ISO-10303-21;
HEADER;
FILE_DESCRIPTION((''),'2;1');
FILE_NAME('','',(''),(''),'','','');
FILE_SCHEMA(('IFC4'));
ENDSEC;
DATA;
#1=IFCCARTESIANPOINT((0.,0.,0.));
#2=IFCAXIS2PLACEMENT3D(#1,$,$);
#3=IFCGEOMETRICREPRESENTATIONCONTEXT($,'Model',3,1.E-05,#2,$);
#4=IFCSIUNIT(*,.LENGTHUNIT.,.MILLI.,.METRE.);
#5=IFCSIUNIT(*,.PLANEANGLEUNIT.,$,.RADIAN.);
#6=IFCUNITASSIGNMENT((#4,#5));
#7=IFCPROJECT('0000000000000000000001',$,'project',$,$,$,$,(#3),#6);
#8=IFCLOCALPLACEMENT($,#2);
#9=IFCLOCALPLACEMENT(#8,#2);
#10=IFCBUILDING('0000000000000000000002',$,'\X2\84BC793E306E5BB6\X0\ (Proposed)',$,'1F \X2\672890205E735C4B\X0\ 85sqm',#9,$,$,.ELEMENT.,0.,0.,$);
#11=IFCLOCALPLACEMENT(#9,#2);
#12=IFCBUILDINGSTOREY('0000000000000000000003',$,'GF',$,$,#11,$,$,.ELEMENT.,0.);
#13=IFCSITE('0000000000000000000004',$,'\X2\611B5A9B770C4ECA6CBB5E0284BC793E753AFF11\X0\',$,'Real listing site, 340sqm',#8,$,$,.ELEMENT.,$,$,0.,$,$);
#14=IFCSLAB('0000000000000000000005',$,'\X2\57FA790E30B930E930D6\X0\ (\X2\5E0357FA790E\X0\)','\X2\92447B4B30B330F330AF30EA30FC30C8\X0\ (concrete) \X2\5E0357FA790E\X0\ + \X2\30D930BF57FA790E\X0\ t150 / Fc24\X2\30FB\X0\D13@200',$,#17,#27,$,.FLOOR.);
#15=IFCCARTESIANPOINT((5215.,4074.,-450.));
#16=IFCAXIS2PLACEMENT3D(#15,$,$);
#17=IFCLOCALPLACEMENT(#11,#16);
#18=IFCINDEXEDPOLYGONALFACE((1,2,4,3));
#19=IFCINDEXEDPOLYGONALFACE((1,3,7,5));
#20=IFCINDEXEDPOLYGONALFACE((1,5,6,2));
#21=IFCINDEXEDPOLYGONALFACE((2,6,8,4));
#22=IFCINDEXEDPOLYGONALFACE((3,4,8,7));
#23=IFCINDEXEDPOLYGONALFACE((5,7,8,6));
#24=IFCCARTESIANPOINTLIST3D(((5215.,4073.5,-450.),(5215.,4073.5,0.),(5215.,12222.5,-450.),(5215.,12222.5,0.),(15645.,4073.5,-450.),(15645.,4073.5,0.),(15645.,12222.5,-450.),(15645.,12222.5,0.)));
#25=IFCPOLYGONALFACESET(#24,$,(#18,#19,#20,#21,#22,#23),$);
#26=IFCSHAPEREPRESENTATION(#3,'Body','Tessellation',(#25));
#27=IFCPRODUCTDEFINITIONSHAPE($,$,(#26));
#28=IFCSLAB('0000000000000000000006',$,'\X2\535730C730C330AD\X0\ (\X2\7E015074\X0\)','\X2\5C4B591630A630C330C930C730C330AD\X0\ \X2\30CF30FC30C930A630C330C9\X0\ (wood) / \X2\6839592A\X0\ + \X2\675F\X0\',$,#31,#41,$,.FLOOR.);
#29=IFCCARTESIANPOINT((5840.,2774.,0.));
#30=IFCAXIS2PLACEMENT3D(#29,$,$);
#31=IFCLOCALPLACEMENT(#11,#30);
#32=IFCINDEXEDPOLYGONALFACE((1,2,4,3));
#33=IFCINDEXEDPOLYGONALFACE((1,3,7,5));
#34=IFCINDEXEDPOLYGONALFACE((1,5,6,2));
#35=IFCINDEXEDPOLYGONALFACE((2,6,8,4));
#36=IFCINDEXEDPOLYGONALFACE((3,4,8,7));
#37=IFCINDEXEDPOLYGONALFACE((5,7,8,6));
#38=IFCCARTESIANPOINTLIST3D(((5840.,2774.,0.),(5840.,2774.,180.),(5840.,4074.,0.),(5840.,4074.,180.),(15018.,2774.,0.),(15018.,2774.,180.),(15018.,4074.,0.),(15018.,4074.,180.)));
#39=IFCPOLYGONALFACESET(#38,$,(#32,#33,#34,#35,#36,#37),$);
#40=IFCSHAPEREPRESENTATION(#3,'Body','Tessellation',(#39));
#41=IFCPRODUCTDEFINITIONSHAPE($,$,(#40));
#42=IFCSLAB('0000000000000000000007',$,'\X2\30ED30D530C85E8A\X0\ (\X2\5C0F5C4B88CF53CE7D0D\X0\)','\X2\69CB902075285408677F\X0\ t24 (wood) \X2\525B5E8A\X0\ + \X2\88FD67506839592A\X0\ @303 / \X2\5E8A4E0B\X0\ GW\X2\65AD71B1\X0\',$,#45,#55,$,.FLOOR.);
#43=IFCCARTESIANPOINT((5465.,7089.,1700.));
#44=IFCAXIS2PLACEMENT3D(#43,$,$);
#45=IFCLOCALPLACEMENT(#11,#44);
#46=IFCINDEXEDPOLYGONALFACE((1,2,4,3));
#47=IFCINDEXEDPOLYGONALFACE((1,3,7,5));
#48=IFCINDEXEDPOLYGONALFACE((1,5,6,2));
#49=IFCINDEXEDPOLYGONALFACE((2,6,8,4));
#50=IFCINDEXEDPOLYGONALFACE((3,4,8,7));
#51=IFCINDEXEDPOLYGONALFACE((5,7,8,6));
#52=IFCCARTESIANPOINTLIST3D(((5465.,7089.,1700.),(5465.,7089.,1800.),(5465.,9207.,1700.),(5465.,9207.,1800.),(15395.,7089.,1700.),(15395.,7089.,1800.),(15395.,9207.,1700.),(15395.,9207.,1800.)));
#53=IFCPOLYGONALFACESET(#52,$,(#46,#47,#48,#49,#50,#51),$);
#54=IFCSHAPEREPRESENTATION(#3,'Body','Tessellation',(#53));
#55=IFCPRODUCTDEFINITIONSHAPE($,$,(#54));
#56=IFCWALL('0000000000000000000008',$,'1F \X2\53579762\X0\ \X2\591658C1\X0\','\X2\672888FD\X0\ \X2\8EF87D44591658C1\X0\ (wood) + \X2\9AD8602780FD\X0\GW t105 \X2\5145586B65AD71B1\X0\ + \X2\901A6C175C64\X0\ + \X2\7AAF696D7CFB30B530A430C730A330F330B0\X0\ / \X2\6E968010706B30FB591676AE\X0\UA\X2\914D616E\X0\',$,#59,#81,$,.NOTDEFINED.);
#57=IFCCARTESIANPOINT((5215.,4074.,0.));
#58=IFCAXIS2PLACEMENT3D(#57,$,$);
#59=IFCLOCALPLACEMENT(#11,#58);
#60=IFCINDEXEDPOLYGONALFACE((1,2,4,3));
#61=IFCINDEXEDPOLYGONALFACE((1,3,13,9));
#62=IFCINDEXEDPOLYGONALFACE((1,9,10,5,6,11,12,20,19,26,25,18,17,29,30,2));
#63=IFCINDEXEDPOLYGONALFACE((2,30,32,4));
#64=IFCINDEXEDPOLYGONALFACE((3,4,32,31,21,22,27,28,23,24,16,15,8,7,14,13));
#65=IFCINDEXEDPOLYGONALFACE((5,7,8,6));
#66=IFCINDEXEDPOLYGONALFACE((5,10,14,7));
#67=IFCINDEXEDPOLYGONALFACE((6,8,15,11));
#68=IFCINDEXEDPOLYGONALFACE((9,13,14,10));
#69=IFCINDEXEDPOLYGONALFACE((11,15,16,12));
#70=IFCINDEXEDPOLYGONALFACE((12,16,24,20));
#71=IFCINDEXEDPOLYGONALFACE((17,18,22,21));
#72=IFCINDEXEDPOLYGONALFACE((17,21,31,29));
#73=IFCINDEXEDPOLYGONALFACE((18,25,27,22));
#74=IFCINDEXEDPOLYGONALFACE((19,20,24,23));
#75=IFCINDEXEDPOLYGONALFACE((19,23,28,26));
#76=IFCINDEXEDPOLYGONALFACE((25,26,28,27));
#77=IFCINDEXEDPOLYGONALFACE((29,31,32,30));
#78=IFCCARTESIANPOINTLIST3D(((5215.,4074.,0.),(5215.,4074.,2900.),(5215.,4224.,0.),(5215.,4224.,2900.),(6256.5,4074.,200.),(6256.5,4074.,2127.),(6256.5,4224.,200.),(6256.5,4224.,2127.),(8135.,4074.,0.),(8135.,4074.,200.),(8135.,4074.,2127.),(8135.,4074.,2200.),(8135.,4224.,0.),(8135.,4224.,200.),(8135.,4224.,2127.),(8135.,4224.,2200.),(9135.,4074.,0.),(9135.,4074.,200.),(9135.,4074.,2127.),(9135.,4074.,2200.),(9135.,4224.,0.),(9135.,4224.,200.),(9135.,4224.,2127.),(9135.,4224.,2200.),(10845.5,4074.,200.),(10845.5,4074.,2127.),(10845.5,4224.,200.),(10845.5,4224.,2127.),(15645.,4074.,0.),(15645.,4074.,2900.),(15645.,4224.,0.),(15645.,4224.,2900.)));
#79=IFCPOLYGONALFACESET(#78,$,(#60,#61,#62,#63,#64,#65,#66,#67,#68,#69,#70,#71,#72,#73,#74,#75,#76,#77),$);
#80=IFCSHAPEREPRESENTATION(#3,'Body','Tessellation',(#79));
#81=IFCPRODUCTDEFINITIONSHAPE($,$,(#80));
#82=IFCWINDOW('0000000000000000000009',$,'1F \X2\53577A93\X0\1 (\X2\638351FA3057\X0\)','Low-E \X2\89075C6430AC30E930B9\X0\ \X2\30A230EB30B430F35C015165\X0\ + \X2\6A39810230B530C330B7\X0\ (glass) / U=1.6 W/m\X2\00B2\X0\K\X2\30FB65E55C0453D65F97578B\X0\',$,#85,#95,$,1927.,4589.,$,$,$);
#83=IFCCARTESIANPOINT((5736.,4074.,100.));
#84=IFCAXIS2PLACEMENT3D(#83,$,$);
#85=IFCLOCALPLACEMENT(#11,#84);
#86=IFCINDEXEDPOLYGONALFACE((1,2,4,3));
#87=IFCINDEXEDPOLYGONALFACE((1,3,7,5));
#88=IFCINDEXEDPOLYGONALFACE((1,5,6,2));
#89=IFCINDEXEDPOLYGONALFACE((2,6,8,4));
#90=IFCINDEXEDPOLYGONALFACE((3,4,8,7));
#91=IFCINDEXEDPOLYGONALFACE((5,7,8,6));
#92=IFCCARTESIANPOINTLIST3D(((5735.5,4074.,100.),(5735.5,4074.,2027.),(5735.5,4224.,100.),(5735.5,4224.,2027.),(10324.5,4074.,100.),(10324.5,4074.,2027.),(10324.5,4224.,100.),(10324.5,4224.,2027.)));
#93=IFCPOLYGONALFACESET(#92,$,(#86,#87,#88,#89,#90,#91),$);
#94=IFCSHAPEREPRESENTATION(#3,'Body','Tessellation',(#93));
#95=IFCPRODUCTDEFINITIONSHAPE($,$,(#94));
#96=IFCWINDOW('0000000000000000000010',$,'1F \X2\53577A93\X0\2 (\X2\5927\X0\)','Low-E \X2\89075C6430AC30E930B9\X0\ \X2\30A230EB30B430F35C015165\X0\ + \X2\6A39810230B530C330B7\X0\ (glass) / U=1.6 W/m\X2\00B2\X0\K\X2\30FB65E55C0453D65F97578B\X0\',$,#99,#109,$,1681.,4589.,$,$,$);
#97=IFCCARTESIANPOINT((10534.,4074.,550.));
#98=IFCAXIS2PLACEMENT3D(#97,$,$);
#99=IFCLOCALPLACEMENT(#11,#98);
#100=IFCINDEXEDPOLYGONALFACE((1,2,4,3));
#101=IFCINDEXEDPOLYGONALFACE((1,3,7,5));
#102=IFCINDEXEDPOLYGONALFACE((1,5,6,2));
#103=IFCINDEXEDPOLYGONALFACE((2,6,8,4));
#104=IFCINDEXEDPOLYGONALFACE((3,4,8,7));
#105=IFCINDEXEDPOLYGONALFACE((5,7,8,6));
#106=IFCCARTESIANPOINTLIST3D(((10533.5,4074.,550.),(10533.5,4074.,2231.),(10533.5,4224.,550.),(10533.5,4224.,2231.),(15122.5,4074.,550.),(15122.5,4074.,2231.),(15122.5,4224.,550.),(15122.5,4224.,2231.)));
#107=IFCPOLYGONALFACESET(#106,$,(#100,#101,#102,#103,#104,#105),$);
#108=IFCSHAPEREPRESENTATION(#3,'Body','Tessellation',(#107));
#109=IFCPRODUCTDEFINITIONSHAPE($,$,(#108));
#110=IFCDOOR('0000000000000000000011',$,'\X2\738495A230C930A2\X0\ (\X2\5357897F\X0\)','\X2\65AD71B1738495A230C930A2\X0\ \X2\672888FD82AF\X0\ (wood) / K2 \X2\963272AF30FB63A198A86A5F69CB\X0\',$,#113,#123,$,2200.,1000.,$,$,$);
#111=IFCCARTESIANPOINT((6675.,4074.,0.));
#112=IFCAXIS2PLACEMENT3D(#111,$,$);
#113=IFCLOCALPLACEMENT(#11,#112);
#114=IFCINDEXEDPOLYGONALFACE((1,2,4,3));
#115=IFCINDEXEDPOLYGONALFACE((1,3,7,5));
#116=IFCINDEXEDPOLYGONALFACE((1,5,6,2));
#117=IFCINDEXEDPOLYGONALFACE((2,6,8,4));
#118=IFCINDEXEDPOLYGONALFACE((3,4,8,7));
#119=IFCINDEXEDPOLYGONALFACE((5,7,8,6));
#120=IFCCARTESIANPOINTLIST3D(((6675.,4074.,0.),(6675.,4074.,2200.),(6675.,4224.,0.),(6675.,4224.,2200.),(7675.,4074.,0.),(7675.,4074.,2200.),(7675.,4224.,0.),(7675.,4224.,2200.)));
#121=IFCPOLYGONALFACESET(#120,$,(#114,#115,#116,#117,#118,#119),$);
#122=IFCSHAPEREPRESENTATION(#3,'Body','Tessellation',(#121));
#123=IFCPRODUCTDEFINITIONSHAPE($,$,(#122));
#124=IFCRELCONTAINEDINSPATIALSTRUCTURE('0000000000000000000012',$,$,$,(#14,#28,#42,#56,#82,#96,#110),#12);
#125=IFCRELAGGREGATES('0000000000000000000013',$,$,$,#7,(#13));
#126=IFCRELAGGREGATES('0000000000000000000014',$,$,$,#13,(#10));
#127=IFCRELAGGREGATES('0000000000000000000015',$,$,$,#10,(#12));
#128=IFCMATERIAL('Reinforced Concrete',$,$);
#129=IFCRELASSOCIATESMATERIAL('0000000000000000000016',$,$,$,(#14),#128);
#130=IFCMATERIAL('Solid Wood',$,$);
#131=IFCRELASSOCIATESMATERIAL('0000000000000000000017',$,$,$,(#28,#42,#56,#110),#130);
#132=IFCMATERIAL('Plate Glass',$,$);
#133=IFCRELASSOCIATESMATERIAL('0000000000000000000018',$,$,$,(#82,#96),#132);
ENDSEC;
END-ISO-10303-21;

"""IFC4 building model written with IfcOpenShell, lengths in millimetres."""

from ifc_helpers import new_model, si_unit, frame, frame_2d, origin, place, context, project, spatial, rectangle, extrude, material, element, fill, save


model = new_model("IFC4")

# Units and contexts
model_context = context("Model", 3, precision=1e-05, world=origin())
ifc_project = project(units=[si_unit("LENGTHUNIT", "METRE", prefix="MILLI"), si_unit("PLANEANGLEUNIT", "RADIAN")], contexts=[model_context])

# Site, building, storey
site_placement = place(None, origin())
site = spatial("IfcSite", under=ifc_project, at=site_placement, Name="愛媛県今治市蒼社町１", ObjectType="Real listing site, 340sqm", CompositionType="ELEMENT", RefElevation=0.0)
building_placement = place(site_placement, origin())
building = spatial("IfcBuilding", under=site, at=building_placement, Name="蒼社の家 (Proposed)", ObjectType="1F 木造平屋 85sqm", CompositionType="ELEMENT", ElevationOfRefHeight=0.0, ElevationOfTerrain=0.0)
storey_placement = place(building_placement, origin())
storey = spatial("IfcBuildingStorey", under=building, at=storey_placement, Name="GF", CompositionType="ELEMENT", Elevation=0.0)

# Slabs
ifc_material_1 = material(Name="Reinforced Concrete")
slab_1_placement = place(storey_placement, frame((5215.0, 4074.0, -450.0)))
element("IfcSlab", 1, at=slab_1_placement, inside=storey, material=ifc_material_1, Name="基礎スラブ (布基礎)", Description="鉄筋コンクリート (concrete) 布基礎 + ベタ基礎 t150 / Fc24・D13@200", PredefinedType="FLOOR", context=model_context, shape_type="SweptSolid", body=[
    extrude(rectangle(XDim=10430.0, YDim=8149.0, at=frame_2d((5215.0, 4074.0))), frame((5215.0, 4074.0, -450.0)), (0.0, 0.0, 1.0), 450.0),
])
ifc_material_2 = material(Name="Solid Wood")
slab_2_placement = place(storey_placement, frame((5840.0, 2774.0, 0.0)))
element("IfcSlab", 2, at=slab_2_placement, inside=storey, material=ifc_material_2, Name="南デッキ (縁側)", Description="屋外ウッドデッキ ハードウッド (wood) / 根太 + 束", PredefinedType="FLOOR", context=model_context, shape_type="SweptSolid", body=[
    extrude(rectangle(XDim=9178.0, YDim=1300.0, at=frame_2d((4589.0, 650.0))), frame((5840.0, 2774.0, 0.0)), (0.0, 0.0, 1.0), 180.0),
])
slab_3_placement = place(storey_placement, frame((5465.0, 7089.0, 1700.0)))
element("IfcSlab", 3, at=slab_3_placement, inside=storey, material=ifc_material_2, Name="ロフト床 (小屋裏収納)", Description="構造用合板 t24 (wood) 剛床 + 製材根太 @303 / 床下 GW断熱", PredefinedType="FLOOR", context=model_context, shape_type="SweptSolid", body=[
    extrude(rectangle(XDim=9930.0, YDim=2118.0, at=frame_2d((4965.0, 1059.0))), frame((5465.0, 7089.0, 1700.0)), (0.0, 0.0, 1.0), 100.0),
])

# Wall, openings, windows, door
wall_1_placement = place(storey_placement, frame((5215.0, 4074.0, 0.0)))
wall_1 = element("IfcWall", 4, at=wall_1_placement, inside=storey, material=ifc_material_2, Name="1F 南面 外壁", Description="木製 軸組外壁 (wood) + 高性能GW t105 充填断熱 + 通気層 + 窯業系サイディング / 準耐火・外皮UA配慮", PredefinedType="NOTDEFINED", context=model_context, shape_type="SweptSolid", body=[
    extrude(rectangle(XDim=10430.0, YDim=150.0, at=frame_2d((5215.0, 75.0))), frame((5215.0, 4074.0, 0.0)), (0.0, 0.0, 1.0), 2900.0),
])
opening_1_placement = place(storey_placement, frame((5736.0, 4074.0, 100.0)))
opening_1 = element("IfcOpeningElement", 5, at=opening_1_placement, cuts=wall_1, PredefinedType="NOTDEFINED", context=model_context, shape_type="SweptSolid", body=[
    extrude(rectangle(XDim=4589.0, YDim=150.0, at=frame_2d((2294.0, 75.0))), frame((5736.0, 4074.0, 100.0)), (0.0, 0.0, 1.0), 1927.0),
])
opening_2_placement = place(storey_placement, frame((10534.0, 4074.0, 550.0)))
opening_2 = element("IfcOpeningElement", 6, at=opening_2_placement, cuts=wall_1, PredefinedType="NOTDEFINED", context=model_context, shape_type="SweptSolid", body=[
    extrude(rectangle(XDim=4589.0, YDim=150.0, at=frame_2d((2294.0, 75.0))), frame((10534.0, 4074.0, 550.0)), (0.0, 0.0, 1.0), 1681.0),
])
opening_3_placement = place(storey_placement, frame((6675.0, 4074.0, 0.0)))
opening_3 = element("IfcOpeningElement", 7, at=opening_3_placement, cuts=wall_1, PredefinedType="NOTDEFINED", context=model_context, shape_type="SweptSolid", body=[
    extrude(rectangle(XDim=1000.0, YDim=150.0, at=frame_2d((500.0, 75.0))), frame((6675.0, 4074.0, 0.0)), (0.0, 0.0, 1.0), 2200.0),
])
ifc_material_3 = material(Name="Plate Glass")
window_1_placement = place(storey_placement, frame((5736.0, 4074.0, 100.0)))
window_1 = element("IfcWindow", 8, at=window_1_placement, inside=storey, material=ifc_material_3, Name="1F 南窓1 (掃出し)", Description="Low-E 複層ガラス アルゴン封入 + 樹脂サッシ (glass) / U=1.6 W/m²K・日射取得型", OverallHeight=1927.0, OverallWidth=4589.0, context=model_context, shape_type="SweptSolid", body=[
    extrude(rectangle(XDim=4589.0, YDim=150.0, at=frame_2d((2294.0, 75.0))), frame((5736.0, 4074.0, 100.0)), (0.0, 0.0, 1.0), 1927.0),
])
fill(opening_1, window_1)
window_2_placement = place(storey_placement, frame((10534.0, 4074.0, 550.0)))
window_2 = element("IfcWindow", 9, at=window_2_placement, inside=storey, material=ifc_material_3, Name="1F 南窓2 (大)", Description="Low-E 複層ガラス アルゴン封入 + 樹脂サッシ (glass) / U=1.6 W/m²K・日射取得型", OverallHeight=1681.0, OverallWidth=4589.0, context=model_context, shape_type="SweptSolid", body=[
    extrude(rectangle(XDim=4589.0, YDim=150.0, at=frame_2d((2294.0, 75.0))), frame((10534.0, 4074.0, 550.0)), (0.0, 0.0, 1.0), 1681.0),
])
fill(opening_2, window_2)
door_1_placement = place(storey_placement, frame((6675.0, 4074.0, 0.0)))
door_1 = element("IfcDoor", 10, at=door_1_placement, inside=storey, material=ifc_material_2, Name="玄関ドア (南西)", Description="断熱玄関ドア 木製芯 (wood) / K2 防犯・採風機構", OverallHeight=2200.0, OverallWidth=1000.0, context=model_context, shape_type="SweptSolid", body=[
    extrude(rectangle(XDim=1000.0, YDim=150.0, at=frame_2d((500.0, 75.0))), frame((6675.0, 4074.0, 0.0)), (0.0, 0.0, 1.0), 2200.0),
])
fill(opening_3, door_1)

save(model, "model.ifc")
